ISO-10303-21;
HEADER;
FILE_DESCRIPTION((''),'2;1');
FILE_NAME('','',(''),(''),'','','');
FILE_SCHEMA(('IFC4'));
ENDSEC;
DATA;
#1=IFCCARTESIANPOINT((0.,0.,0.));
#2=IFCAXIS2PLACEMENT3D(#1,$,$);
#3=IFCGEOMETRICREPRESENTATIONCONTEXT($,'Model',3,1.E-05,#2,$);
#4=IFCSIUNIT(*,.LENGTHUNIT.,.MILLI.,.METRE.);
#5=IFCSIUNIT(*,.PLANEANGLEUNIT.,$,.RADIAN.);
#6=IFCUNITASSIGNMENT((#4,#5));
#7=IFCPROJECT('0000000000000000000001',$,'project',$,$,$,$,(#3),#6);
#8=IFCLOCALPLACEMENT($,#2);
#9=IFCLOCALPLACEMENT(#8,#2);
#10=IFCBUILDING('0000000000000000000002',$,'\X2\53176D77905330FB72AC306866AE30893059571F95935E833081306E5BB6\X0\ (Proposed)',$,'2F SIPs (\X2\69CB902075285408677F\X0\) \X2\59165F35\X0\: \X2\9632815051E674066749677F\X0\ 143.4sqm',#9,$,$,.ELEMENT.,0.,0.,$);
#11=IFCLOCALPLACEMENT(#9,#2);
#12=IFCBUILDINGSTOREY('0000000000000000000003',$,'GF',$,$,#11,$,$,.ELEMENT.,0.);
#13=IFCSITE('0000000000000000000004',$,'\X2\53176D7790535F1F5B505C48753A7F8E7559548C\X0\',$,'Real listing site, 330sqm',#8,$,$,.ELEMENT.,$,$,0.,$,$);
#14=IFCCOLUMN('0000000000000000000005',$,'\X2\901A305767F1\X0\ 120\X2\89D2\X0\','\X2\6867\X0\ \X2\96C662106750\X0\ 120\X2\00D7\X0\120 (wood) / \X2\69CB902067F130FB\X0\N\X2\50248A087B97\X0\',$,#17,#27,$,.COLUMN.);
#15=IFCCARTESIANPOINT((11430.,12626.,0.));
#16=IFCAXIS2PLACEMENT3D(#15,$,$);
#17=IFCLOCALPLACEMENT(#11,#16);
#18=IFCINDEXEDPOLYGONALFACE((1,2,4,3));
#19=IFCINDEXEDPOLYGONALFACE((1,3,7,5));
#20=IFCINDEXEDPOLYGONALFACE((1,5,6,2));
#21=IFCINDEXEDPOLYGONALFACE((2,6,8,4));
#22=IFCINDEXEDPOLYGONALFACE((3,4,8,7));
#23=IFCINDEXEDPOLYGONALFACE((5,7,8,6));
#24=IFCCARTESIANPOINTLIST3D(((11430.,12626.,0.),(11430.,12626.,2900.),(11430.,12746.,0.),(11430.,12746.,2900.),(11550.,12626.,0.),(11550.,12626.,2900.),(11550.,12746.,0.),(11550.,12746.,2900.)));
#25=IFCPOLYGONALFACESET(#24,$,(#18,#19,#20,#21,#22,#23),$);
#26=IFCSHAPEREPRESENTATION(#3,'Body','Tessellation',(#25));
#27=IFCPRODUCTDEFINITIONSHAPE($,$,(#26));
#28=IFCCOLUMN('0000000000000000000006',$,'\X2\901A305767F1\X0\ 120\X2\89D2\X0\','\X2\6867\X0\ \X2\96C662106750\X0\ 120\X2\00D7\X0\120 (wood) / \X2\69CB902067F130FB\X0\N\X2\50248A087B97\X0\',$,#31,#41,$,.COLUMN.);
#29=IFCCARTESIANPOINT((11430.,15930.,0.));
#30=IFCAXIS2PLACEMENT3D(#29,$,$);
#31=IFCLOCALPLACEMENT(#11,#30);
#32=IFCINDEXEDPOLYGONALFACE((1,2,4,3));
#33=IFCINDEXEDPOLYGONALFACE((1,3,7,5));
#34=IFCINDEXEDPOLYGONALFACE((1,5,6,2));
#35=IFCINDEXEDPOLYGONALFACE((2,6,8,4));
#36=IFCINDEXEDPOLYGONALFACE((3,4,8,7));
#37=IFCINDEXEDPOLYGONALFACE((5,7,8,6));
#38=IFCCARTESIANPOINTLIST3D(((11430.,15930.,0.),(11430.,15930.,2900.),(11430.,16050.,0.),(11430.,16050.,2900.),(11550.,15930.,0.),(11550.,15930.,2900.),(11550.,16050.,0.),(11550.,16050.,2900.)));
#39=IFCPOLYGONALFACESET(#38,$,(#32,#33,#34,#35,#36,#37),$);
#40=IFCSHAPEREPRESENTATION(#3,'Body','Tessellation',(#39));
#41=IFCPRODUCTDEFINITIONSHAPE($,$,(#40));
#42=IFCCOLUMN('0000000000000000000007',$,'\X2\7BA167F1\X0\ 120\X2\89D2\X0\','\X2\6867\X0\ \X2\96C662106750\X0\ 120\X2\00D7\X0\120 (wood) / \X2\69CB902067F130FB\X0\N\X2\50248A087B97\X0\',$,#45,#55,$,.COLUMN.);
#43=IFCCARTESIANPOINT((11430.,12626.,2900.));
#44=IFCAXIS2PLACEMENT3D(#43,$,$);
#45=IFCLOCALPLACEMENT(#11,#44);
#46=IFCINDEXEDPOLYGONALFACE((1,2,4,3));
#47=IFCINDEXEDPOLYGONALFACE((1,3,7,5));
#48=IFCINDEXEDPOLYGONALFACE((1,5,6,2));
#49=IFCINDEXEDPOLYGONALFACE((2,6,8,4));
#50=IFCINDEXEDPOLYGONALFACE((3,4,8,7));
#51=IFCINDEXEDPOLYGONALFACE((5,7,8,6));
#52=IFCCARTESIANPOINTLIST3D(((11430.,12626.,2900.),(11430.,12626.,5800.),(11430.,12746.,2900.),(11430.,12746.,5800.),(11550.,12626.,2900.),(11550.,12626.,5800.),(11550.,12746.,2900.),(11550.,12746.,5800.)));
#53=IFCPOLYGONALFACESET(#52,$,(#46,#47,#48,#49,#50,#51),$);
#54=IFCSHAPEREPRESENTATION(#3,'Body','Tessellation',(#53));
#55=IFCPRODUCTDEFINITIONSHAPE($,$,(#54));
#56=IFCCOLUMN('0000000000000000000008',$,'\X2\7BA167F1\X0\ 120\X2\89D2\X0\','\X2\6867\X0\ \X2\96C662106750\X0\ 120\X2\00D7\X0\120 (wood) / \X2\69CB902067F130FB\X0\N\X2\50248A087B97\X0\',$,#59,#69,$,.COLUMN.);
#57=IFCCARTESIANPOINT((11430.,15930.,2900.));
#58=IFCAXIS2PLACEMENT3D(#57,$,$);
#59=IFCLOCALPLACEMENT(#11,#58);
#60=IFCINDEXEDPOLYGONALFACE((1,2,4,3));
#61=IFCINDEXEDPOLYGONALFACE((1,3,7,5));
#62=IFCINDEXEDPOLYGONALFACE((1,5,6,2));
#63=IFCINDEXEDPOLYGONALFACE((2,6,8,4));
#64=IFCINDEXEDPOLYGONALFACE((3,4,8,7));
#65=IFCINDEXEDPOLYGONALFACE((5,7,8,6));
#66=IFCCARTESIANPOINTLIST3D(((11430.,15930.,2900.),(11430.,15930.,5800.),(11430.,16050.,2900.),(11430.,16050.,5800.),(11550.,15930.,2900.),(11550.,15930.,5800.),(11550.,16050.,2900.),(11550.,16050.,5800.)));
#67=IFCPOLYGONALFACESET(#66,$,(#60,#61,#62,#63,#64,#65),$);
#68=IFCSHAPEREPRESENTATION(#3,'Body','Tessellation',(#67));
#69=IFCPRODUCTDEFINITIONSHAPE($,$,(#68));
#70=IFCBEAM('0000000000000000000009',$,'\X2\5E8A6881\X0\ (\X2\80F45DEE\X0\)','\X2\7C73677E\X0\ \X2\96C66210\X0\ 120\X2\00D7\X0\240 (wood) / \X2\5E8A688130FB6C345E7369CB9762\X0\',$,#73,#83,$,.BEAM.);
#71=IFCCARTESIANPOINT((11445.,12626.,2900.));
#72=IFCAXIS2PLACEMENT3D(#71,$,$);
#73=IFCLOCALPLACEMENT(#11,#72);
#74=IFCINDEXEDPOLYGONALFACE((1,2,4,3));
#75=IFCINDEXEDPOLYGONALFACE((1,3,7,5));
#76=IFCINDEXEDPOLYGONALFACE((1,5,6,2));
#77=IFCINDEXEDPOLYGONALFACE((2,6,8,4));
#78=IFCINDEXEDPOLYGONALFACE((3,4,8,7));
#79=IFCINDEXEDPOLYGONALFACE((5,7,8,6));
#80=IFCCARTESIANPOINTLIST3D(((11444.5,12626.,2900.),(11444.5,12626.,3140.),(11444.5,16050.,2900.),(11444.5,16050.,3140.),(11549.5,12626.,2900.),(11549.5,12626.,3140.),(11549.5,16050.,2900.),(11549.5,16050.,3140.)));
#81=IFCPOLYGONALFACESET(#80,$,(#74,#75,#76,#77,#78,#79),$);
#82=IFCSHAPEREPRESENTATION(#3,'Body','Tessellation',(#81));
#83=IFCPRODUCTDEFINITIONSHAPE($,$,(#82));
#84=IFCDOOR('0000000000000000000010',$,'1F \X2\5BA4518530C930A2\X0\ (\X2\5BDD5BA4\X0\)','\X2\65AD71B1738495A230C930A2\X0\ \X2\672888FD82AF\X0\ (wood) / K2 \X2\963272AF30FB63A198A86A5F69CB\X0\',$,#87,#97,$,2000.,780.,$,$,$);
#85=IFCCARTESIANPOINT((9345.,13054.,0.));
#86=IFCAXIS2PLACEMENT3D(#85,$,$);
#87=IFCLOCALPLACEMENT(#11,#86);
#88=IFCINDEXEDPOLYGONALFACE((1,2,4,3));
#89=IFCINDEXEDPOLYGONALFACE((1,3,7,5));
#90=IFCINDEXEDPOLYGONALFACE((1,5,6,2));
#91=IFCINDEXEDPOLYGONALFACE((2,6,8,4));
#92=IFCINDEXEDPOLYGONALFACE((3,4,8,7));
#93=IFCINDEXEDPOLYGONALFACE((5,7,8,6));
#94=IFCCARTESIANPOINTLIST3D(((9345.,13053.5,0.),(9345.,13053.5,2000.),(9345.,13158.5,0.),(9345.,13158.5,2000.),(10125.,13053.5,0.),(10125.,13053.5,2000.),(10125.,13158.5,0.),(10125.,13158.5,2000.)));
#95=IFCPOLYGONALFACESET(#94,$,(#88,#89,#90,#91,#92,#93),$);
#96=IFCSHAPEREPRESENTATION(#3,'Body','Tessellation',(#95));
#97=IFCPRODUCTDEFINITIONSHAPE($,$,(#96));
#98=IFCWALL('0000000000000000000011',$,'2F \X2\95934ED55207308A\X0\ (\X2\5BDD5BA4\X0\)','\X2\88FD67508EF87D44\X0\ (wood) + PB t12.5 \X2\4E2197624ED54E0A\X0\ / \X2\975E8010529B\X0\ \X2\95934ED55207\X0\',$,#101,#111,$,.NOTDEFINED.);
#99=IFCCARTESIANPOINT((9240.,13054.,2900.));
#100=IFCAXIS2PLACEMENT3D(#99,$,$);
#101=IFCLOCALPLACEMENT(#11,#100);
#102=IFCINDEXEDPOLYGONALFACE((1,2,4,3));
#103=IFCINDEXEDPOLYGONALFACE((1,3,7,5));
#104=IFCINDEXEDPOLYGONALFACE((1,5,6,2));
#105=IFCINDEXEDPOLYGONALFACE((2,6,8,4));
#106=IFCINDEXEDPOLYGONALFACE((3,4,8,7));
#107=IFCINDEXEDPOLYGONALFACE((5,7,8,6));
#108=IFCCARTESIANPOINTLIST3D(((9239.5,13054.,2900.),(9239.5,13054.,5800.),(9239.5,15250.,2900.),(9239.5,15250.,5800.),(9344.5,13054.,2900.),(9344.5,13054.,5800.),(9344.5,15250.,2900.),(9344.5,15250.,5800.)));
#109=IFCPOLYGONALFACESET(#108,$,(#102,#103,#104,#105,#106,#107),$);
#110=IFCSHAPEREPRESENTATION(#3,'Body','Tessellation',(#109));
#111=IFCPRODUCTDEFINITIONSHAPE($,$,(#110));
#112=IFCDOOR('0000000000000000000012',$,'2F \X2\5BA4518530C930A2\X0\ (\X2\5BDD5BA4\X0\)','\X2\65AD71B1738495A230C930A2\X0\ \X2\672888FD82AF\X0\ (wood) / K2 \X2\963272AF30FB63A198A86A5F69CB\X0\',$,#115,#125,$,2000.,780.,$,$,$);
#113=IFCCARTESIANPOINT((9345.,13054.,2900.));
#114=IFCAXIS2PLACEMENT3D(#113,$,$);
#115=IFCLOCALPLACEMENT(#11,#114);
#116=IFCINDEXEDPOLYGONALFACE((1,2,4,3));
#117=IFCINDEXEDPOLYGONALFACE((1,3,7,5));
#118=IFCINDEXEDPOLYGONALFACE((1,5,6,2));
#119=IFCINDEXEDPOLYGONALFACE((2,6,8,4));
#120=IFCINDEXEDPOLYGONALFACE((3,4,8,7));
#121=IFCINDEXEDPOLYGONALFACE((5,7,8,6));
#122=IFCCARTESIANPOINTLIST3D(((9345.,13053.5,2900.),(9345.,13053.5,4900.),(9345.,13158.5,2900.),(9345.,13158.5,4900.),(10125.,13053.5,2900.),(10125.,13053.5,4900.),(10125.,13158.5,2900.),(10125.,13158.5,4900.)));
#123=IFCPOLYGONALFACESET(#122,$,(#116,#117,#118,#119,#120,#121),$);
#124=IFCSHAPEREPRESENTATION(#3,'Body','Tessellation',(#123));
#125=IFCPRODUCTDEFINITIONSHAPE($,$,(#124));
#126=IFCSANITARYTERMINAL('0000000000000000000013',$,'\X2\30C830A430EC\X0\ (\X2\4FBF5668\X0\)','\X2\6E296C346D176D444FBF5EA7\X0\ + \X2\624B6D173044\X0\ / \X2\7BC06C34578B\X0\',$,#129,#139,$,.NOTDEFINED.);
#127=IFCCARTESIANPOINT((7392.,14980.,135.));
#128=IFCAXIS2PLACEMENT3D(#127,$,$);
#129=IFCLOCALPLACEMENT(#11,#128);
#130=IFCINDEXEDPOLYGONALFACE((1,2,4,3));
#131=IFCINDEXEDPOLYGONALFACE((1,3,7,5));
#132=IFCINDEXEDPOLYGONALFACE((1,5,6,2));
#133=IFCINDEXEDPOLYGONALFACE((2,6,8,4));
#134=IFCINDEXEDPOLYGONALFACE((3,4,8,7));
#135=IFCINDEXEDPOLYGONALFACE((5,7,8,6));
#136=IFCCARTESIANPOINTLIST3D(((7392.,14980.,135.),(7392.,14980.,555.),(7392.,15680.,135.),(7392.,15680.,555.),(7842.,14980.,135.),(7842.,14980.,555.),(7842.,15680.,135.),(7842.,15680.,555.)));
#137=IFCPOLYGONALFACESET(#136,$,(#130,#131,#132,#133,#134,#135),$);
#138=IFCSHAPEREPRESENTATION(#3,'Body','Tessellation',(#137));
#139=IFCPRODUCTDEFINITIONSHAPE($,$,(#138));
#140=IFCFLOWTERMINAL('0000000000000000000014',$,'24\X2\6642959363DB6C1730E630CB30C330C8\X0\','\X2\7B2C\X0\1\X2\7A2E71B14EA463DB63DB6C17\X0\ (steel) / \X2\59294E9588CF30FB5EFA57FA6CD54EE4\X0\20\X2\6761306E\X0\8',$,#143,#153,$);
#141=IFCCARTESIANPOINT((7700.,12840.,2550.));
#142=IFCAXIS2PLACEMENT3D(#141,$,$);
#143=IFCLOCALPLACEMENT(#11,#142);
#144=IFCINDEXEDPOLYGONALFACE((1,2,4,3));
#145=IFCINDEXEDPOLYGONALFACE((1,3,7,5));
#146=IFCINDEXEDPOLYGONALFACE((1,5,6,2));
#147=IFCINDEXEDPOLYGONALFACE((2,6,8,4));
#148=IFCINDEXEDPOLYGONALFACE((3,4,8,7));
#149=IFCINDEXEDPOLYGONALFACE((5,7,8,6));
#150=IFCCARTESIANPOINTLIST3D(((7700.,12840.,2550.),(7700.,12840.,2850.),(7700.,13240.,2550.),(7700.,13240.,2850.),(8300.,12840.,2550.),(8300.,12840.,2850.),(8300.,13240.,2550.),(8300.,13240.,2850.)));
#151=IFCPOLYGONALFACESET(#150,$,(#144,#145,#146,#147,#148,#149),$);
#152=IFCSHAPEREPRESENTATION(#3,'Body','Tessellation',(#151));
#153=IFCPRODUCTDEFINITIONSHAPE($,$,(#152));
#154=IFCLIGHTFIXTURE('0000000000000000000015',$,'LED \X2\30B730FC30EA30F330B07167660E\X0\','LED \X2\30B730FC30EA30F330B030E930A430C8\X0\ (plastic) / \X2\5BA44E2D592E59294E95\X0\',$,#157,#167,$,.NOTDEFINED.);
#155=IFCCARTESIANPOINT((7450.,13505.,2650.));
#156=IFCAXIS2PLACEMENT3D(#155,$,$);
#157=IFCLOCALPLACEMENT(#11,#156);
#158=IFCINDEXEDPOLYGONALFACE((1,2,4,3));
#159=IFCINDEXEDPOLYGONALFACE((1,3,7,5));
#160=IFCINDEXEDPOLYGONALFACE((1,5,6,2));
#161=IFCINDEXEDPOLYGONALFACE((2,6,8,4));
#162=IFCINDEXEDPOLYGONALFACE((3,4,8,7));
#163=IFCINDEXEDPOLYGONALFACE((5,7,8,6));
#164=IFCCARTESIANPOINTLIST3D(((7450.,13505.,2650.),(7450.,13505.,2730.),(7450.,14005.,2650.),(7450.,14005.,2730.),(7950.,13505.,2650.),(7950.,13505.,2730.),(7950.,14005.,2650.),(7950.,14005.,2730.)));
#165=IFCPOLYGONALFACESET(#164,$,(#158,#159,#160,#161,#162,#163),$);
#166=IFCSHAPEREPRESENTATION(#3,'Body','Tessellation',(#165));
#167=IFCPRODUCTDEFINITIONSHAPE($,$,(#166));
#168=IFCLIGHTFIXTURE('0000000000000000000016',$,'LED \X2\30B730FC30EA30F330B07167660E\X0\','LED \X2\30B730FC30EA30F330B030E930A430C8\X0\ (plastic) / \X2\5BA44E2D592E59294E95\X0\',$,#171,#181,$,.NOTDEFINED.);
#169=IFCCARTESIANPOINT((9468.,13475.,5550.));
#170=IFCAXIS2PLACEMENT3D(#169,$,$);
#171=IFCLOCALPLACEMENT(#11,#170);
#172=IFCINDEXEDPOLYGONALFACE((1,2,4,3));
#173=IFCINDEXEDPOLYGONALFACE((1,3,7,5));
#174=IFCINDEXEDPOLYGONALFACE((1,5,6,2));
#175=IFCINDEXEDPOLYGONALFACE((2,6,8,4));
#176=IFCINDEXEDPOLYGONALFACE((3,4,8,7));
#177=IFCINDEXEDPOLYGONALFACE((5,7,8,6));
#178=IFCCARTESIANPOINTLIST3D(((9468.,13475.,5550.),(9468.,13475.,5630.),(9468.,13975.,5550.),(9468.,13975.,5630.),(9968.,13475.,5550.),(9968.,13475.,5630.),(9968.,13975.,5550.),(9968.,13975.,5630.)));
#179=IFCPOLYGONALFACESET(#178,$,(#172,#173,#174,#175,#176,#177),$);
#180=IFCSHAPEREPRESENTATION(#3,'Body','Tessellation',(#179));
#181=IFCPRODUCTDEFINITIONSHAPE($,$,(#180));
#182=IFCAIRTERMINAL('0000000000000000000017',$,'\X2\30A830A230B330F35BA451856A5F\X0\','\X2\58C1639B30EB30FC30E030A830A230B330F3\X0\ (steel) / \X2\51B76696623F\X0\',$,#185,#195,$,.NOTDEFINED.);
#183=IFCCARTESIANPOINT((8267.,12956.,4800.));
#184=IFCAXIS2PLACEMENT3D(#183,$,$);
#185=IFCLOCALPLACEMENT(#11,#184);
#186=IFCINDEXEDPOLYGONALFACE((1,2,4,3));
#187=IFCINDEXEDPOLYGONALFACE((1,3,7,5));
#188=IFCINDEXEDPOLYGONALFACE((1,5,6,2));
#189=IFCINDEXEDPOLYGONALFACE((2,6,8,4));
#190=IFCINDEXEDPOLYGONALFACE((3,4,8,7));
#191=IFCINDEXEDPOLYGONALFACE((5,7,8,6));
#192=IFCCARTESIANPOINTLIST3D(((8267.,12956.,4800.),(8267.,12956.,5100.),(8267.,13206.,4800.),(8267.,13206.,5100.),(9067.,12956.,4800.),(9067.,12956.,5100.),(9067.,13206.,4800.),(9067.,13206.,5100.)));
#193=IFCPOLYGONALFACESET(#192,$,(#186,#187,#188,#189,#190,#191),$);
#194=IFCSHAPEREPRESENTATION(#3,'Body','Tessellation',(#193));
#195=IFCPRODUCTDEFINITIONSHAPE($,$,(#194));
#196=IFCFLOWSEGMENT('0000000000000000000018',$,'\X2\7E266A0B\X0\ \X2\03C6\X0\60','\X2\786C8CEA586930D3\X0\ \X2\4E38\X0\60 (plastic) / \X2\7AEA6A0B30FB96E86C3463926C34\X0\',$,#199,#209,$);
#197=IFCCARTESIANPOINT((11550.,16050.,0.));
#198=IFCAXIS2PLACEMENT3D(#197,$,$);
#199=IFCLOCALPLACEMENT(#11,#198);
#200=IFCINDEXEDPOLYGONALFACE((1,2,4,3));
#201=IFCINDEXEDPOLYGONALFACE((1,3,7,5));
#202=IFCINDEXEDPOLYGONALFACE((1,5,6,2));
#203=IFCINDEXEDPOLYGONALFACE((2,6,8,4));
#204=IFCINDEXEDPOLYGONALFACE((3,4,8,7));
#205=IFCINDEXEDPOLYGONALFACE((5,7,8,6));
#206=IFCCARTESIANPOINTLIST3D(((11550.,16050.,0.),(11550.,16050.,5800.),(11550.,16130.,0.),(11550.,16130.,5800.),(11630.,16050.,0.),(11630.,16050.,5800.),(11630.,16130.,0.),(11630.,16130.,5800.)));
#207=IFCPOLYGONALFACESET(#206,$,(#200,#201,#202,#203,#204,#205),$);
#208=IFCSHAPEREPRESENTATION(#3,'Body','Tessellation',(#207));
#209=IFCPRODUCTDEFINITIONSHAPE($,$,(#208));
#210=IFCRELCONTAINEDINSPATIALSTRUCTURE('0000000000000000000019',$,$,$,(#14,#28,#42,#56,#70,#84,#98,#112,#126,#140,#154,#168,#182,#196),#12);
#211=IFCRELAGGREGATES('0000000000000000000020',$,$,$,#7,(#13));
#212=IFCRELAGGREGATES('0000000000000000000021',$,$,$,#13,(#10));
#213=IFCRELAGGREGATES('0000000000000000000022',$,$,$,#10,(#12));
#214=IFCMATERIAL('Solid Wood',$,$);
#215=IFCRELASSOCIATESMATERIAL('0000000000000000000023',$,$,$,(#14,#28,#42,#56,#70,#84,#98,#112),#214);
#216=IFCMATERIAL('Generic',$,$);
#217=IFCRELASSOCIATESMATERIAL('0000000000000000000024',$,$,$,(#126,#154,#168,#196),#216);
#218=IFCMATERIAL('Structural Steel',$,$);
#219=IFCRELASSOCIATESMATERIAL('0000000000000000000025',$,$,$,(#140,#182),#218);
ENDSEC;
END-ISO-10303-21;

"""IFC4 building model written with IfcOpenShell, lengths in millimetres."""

from ifc_helpers import new_model, si_unit, frame, frame_2d, origin, place, context, project, spatial, rectangle, extrude, material, element, save


model = new_model("IFC4")

# Units and contexts
model_context = context("Model", 3, precision=1e-05, world=origin())
ifc_project = project(units=[si_unit("LENGTHUNIT", "METRE", prefix="MILLI"), si_unit("PLANEANGLEUNIT", "RADIAN")], contexts=[model_context])

# Site, building, storey
site_placement = place(None, origin())
site = spatial("IfcSite", under=ifc_project, at=site_placement, Name="北海道弟子屈町美留和", ObjectType="Real listing site, 330sqm", CompositionType="ELEMENT", RefElevation=0.0)
building_placement = place(site_placement, origin())
building = spatial("IfcBuilding", under=site, at=building_placement, Name="北海道・犬と暮らす土間広めの家 (Proposed)", ObjectType="2F SIPs (構造用合板) 外張: 防腐処理杉板 143.4sqm", CompositionType="ELEMENT", ElevationOfRefHeight=0.0, ElevationOfTerrain=0.0)
storey_placement = place(building_placement, origin())
storey = spatial("IfcBuildingStorey", under=building, at=storey_placement, Name="GF", CompositionType="ELEMENT", Elevation=0.0)

# Columns
ifc_material_1 = material(Name="Solid Wood")
column_1_placement = place(storey_placement, frame((11430.0, 12626.0, 0.0)))
element("IfcColumn", 1, at=column_1_placement, inside=storey, material=ifc_material_1, Name="通し柱 120角", Description="桧 集成材 120×120 (wood) / 構造柱・N値計算", PredefinedType="COLUMN", context=model_context, shape_type="SweptSolid", body=[
    extrude(rectangle(XDim=120.0, YDim=120.0, at=frame_2d((60.0, 60.0))), frame((11430.0, 12626.0, 0.0)), (0.0, 0.0, 1.0), 2900.0),
])
column_2_placement = place(storey_placement, frame((11430.0, 15930.0, 0.0)))
element("IfcColumn", 2, at=column_2_placement, inside=storey, material=ifc_material_1, Name="通し柱 120角", Description="桧 集成材 120×120 (wood) / 構造柱・N値計算", PredefinedType="COLUMN", context=model_context, shape_type="SweptSolid", body=[
    extrude(rectangle(XDim=120.0, YDim=120.0, at=frame_2d((60.0, 60.0))), frame((11430.0, 15930.0, 0.0)), (0.0, 0.0, 1.0), 2900.0),
])
column_3_placement = place(storey_placement, frame((11430.0, 12626.0, 2900.0)))
element("IfcColumn", 3, at=column_3_placement, inside=storey, material=ifc_material_1, Name="管柱 120角", Description="桧 集成材 120×120 (wood) / 構造柱・N値計算", PredefinedType="COLUMN", context=model_context, shape_type="SweptSolid", body=[
    extrude(rectangle(XDim=120.0, YDim=120.0, at=frame_2d((60.0, 60.0))), frame((11430.0, 12626.0, 2900.0)), (0.0, 0.0, 1.0), 2900.0),
])
column_4_placement = place(storey_placement, frame((11430.0, 15930.0, 2900.0)))
element("IfcColumn", 4, at=column_4_placement, inside=storey, material=ifc_material_1, Name="管柱 120角", Description="桧 集成材 120×120 (wood) / 構造柱・N値計算", PredefinedType="COLUMN", context=model_context, shape_type="SweptSolid", body=[
    extrude(rectangle(XDim=120.0, YDim=120.0, at=frame_2d((60.0, 60.0))), frame((11430.0, 15930.0, 2900.0)), (0.0, 0.0, 1.0), 2900.0),
])

# Beam
beam_1_placement = place(storey_placement, frame((11445.0, 12626.0, 2900.0)))
element("IfcBeam", 5, at=beam_1_placement, inside=storey, material=ifc_material_1, Name="床梁 (胴差)", Description="米松 集成 120×240 (wood) / 床梁・水平構面", PredefinedType="BEAM", context=model_context, shape_type="SweptSolid", body=[
    extrude(rectangle(XDim=105.0, YDim=3424.0, at=frame_2d((52.0, 1712.0))), frame((11445.0, 12626.0, 2900.0)), (0.0, 0.0, 1.0), 240.0),
])

# Door
door_1_placement = place(storey_placement, frame((9345.0, 13054.0, 0.0)))
element("IfcDoor", 6, at=door_1_placement, inside=storey, material=ifc_material_1, Name="1F 室内ドア (寝室)", Description="断熱玄関ドア 木製芯 (wood) / K2 防犯・採風機構", OverallHeight=2000.0, OverallWidth=780.0, context=model_context, shape_type="SweptSolid", body=[
    extrude(rectangle(XDim=780.0, YDim=105.0, at=frame_2d((390.0, 52.0))), frame((9345.0, 13054.0, 0.0)), (0.0, 0.0, 1.0), 2000.0),
])

# Wall
wall_1_placement = place(storey_placement, frame((9240.0, 13054.0, 2900.0)))
element("IfcWall", 7, at=wall_1_placement, inside=storey, material=ifc_material_1, Name="2F 間仕切り (寝室)", Description="製材軸組 (wood) + PB t12.5 両面仕上 / 非耐力 間仕切", PredefinedType="NOTDEFINED", context=model_context, shape_type="SweptSolid", body=[
    extrude(rectangle(XDim=105.0, YDim=2196.0, at=frame_2d((52.0, 1098.0))), frame((9240.0, 13054.0, 2900.0)), (0.0, 0.0, 1.0), 2900.0),
])

# Door
door_2_placement = place(storey_placement, frame((9345.0, 13054.0, 2900.0)))
element("IfcDoor", 8, at=door_2_placement, inside=storey, material=ifc_material_1, Name="2F 室内ドア (寝室)", Description="断熱玄関ドア 木製芯 (wood) / K2 防犯・採風機構", OverallHeight=2000.0, OverallWidth=780.0, context=model_context, shape_type="SweptSolid", body=[
    extrude(rectangle(XDim=780.0, YDim=105.0, at=frame_2d((390.0, 52.0))), frame((9345.0, 13054.0, 2900.0)), (0.0, 0.0, 1.0), 2000.0),
])

# Sanitary terminal
ifc_material_2 = material(Name="Generic")
sanitary_terminal_placement = place(storey_placement, frame((7392.0, 14980.0, 135.0)))
element("IfcSanitaryTerminal", 9, at=sanitary_terminal_placement, inside=storey, material=ifc_material_2, Name="トイレ (便器)", Description="温水洗浄便座 + 手洗い / 節水型", PredefinedType="NOTDEFINED", context=model_context, shape_type="SweptSolid", body=[
    extrude(rectangle(XDim=450.0, YDim=700.0, at=frame_2d((225.0, 350.0))), frame((7392.0, 14980.0, 135.0)), (0.0, 0.0, 1.0), 420.0),
])

# Flow terminal
ifc_material_3 = material(Name="Structural Steel")
flow_terminal_placement = place(storey_placement, frame((7700.0, 12840.0, 2550.0)))
element("IfcFlowTerminal", 10, at=flow_terminal_placement, inside=storey, material=ifc_material_3, Name="24時間換気ユニット", Description="第1種熱交換換気 (steel) / 天井裏・建基法令20条の8", context=model_context, shape_type="SweptSolid", body=[
    extrude(rectangle(XDim=600.0, YDim=400.0, at=frame_2d((300.0, 200.0))), frame((7700.0, 12840.0, 2550.0)), (0.0, 0.0, 1.0), 300.0),
])

# Light fixtures
light_fixture_1_placement = place(storey_placement, frame((7450.0, 13505.0, 2650.0)))
element("IfcLightFixture", 11, at=light_fixture_1_placement, inside=storey, material=ifc_material_2, Name="LED シーリング照明", Description="LED シーリングライト (plastic) / 室中央天井", PredefinedType="NOTDEFINED", context=model_context, shape_type="SweptSolid", body=[
    extrude(rectangle(XDim=500.0, YDim=500.0, at=frame_2d((250.0, 250.0))), frame((7450.0, 13505.0, 2650.0)), (0.0, 0.0, 1.0), 80.0),
])
light_fixture_2_placement = place(storey_placement, frame((9468.0, 13475.0, 5550.0)))
element("IfcLightFixture", 12, at=light_fixture_2_placement, inside=storey, material=ifc_material_2, Name="LED シーリング照明", Description="LED シーリングライト (plastic) / 室中央天井", PredefinedType="NOTDEFINED", context=model_context, shape_type="SweptSolid", body=[
    extrude(rectangle(XDim=500.0, YDim=500.0, at=frame_2d((250.0, 250.0))), frame((9468.0, 13475.0, 5550.0)), (0.0, 0.0, 1.0), 80.0),
])

# Air terminal
air_terminal_placement = place(storey_placement, frame((8267.0, 12956.0, 4800.0)))
element("IfcAirTerminal", 13, at=air_terminal_placement, inside=storey, material=ifc_material_3, Name="エアコン室内機", Description="壁掛ルームエアコン (steel) / 冷暖房", PredefinedType="NOTDEFINED", context=model_context, shape_type="SweptSolid", body=[
    extrude(rectangle(XDim=800.0, YDim=250.0, at=frame_2d((400.0, 125.0))), frame((8267.0, 12956.0, 4800.0)), (0.0, 0.0, 1.0), 300.0),
])

# Flow segment
flow_segment_placement = place(storey_placement, frame((11550.0, 16050.0, 0.0)))
element("IfcFlowSegment", 14, at=flow_segment_placement, inside=storey, material=ifc_material_2, Name="縦樋 φ60", Description="硬質塩ビ 丸60 (plastic) / 竪樋・雨水排水", context=model_context, shape_type="SweptSolid", body=[
    extrude(rectangle(XDim=80.0, YDim=80.0, at=frame_2d((40.0, 40.0))), frame((11550.0, 16050.0, 0.0)), (0.0, 0.0, 1.0), 5800.0),
])

save(model, "model.ifc")
